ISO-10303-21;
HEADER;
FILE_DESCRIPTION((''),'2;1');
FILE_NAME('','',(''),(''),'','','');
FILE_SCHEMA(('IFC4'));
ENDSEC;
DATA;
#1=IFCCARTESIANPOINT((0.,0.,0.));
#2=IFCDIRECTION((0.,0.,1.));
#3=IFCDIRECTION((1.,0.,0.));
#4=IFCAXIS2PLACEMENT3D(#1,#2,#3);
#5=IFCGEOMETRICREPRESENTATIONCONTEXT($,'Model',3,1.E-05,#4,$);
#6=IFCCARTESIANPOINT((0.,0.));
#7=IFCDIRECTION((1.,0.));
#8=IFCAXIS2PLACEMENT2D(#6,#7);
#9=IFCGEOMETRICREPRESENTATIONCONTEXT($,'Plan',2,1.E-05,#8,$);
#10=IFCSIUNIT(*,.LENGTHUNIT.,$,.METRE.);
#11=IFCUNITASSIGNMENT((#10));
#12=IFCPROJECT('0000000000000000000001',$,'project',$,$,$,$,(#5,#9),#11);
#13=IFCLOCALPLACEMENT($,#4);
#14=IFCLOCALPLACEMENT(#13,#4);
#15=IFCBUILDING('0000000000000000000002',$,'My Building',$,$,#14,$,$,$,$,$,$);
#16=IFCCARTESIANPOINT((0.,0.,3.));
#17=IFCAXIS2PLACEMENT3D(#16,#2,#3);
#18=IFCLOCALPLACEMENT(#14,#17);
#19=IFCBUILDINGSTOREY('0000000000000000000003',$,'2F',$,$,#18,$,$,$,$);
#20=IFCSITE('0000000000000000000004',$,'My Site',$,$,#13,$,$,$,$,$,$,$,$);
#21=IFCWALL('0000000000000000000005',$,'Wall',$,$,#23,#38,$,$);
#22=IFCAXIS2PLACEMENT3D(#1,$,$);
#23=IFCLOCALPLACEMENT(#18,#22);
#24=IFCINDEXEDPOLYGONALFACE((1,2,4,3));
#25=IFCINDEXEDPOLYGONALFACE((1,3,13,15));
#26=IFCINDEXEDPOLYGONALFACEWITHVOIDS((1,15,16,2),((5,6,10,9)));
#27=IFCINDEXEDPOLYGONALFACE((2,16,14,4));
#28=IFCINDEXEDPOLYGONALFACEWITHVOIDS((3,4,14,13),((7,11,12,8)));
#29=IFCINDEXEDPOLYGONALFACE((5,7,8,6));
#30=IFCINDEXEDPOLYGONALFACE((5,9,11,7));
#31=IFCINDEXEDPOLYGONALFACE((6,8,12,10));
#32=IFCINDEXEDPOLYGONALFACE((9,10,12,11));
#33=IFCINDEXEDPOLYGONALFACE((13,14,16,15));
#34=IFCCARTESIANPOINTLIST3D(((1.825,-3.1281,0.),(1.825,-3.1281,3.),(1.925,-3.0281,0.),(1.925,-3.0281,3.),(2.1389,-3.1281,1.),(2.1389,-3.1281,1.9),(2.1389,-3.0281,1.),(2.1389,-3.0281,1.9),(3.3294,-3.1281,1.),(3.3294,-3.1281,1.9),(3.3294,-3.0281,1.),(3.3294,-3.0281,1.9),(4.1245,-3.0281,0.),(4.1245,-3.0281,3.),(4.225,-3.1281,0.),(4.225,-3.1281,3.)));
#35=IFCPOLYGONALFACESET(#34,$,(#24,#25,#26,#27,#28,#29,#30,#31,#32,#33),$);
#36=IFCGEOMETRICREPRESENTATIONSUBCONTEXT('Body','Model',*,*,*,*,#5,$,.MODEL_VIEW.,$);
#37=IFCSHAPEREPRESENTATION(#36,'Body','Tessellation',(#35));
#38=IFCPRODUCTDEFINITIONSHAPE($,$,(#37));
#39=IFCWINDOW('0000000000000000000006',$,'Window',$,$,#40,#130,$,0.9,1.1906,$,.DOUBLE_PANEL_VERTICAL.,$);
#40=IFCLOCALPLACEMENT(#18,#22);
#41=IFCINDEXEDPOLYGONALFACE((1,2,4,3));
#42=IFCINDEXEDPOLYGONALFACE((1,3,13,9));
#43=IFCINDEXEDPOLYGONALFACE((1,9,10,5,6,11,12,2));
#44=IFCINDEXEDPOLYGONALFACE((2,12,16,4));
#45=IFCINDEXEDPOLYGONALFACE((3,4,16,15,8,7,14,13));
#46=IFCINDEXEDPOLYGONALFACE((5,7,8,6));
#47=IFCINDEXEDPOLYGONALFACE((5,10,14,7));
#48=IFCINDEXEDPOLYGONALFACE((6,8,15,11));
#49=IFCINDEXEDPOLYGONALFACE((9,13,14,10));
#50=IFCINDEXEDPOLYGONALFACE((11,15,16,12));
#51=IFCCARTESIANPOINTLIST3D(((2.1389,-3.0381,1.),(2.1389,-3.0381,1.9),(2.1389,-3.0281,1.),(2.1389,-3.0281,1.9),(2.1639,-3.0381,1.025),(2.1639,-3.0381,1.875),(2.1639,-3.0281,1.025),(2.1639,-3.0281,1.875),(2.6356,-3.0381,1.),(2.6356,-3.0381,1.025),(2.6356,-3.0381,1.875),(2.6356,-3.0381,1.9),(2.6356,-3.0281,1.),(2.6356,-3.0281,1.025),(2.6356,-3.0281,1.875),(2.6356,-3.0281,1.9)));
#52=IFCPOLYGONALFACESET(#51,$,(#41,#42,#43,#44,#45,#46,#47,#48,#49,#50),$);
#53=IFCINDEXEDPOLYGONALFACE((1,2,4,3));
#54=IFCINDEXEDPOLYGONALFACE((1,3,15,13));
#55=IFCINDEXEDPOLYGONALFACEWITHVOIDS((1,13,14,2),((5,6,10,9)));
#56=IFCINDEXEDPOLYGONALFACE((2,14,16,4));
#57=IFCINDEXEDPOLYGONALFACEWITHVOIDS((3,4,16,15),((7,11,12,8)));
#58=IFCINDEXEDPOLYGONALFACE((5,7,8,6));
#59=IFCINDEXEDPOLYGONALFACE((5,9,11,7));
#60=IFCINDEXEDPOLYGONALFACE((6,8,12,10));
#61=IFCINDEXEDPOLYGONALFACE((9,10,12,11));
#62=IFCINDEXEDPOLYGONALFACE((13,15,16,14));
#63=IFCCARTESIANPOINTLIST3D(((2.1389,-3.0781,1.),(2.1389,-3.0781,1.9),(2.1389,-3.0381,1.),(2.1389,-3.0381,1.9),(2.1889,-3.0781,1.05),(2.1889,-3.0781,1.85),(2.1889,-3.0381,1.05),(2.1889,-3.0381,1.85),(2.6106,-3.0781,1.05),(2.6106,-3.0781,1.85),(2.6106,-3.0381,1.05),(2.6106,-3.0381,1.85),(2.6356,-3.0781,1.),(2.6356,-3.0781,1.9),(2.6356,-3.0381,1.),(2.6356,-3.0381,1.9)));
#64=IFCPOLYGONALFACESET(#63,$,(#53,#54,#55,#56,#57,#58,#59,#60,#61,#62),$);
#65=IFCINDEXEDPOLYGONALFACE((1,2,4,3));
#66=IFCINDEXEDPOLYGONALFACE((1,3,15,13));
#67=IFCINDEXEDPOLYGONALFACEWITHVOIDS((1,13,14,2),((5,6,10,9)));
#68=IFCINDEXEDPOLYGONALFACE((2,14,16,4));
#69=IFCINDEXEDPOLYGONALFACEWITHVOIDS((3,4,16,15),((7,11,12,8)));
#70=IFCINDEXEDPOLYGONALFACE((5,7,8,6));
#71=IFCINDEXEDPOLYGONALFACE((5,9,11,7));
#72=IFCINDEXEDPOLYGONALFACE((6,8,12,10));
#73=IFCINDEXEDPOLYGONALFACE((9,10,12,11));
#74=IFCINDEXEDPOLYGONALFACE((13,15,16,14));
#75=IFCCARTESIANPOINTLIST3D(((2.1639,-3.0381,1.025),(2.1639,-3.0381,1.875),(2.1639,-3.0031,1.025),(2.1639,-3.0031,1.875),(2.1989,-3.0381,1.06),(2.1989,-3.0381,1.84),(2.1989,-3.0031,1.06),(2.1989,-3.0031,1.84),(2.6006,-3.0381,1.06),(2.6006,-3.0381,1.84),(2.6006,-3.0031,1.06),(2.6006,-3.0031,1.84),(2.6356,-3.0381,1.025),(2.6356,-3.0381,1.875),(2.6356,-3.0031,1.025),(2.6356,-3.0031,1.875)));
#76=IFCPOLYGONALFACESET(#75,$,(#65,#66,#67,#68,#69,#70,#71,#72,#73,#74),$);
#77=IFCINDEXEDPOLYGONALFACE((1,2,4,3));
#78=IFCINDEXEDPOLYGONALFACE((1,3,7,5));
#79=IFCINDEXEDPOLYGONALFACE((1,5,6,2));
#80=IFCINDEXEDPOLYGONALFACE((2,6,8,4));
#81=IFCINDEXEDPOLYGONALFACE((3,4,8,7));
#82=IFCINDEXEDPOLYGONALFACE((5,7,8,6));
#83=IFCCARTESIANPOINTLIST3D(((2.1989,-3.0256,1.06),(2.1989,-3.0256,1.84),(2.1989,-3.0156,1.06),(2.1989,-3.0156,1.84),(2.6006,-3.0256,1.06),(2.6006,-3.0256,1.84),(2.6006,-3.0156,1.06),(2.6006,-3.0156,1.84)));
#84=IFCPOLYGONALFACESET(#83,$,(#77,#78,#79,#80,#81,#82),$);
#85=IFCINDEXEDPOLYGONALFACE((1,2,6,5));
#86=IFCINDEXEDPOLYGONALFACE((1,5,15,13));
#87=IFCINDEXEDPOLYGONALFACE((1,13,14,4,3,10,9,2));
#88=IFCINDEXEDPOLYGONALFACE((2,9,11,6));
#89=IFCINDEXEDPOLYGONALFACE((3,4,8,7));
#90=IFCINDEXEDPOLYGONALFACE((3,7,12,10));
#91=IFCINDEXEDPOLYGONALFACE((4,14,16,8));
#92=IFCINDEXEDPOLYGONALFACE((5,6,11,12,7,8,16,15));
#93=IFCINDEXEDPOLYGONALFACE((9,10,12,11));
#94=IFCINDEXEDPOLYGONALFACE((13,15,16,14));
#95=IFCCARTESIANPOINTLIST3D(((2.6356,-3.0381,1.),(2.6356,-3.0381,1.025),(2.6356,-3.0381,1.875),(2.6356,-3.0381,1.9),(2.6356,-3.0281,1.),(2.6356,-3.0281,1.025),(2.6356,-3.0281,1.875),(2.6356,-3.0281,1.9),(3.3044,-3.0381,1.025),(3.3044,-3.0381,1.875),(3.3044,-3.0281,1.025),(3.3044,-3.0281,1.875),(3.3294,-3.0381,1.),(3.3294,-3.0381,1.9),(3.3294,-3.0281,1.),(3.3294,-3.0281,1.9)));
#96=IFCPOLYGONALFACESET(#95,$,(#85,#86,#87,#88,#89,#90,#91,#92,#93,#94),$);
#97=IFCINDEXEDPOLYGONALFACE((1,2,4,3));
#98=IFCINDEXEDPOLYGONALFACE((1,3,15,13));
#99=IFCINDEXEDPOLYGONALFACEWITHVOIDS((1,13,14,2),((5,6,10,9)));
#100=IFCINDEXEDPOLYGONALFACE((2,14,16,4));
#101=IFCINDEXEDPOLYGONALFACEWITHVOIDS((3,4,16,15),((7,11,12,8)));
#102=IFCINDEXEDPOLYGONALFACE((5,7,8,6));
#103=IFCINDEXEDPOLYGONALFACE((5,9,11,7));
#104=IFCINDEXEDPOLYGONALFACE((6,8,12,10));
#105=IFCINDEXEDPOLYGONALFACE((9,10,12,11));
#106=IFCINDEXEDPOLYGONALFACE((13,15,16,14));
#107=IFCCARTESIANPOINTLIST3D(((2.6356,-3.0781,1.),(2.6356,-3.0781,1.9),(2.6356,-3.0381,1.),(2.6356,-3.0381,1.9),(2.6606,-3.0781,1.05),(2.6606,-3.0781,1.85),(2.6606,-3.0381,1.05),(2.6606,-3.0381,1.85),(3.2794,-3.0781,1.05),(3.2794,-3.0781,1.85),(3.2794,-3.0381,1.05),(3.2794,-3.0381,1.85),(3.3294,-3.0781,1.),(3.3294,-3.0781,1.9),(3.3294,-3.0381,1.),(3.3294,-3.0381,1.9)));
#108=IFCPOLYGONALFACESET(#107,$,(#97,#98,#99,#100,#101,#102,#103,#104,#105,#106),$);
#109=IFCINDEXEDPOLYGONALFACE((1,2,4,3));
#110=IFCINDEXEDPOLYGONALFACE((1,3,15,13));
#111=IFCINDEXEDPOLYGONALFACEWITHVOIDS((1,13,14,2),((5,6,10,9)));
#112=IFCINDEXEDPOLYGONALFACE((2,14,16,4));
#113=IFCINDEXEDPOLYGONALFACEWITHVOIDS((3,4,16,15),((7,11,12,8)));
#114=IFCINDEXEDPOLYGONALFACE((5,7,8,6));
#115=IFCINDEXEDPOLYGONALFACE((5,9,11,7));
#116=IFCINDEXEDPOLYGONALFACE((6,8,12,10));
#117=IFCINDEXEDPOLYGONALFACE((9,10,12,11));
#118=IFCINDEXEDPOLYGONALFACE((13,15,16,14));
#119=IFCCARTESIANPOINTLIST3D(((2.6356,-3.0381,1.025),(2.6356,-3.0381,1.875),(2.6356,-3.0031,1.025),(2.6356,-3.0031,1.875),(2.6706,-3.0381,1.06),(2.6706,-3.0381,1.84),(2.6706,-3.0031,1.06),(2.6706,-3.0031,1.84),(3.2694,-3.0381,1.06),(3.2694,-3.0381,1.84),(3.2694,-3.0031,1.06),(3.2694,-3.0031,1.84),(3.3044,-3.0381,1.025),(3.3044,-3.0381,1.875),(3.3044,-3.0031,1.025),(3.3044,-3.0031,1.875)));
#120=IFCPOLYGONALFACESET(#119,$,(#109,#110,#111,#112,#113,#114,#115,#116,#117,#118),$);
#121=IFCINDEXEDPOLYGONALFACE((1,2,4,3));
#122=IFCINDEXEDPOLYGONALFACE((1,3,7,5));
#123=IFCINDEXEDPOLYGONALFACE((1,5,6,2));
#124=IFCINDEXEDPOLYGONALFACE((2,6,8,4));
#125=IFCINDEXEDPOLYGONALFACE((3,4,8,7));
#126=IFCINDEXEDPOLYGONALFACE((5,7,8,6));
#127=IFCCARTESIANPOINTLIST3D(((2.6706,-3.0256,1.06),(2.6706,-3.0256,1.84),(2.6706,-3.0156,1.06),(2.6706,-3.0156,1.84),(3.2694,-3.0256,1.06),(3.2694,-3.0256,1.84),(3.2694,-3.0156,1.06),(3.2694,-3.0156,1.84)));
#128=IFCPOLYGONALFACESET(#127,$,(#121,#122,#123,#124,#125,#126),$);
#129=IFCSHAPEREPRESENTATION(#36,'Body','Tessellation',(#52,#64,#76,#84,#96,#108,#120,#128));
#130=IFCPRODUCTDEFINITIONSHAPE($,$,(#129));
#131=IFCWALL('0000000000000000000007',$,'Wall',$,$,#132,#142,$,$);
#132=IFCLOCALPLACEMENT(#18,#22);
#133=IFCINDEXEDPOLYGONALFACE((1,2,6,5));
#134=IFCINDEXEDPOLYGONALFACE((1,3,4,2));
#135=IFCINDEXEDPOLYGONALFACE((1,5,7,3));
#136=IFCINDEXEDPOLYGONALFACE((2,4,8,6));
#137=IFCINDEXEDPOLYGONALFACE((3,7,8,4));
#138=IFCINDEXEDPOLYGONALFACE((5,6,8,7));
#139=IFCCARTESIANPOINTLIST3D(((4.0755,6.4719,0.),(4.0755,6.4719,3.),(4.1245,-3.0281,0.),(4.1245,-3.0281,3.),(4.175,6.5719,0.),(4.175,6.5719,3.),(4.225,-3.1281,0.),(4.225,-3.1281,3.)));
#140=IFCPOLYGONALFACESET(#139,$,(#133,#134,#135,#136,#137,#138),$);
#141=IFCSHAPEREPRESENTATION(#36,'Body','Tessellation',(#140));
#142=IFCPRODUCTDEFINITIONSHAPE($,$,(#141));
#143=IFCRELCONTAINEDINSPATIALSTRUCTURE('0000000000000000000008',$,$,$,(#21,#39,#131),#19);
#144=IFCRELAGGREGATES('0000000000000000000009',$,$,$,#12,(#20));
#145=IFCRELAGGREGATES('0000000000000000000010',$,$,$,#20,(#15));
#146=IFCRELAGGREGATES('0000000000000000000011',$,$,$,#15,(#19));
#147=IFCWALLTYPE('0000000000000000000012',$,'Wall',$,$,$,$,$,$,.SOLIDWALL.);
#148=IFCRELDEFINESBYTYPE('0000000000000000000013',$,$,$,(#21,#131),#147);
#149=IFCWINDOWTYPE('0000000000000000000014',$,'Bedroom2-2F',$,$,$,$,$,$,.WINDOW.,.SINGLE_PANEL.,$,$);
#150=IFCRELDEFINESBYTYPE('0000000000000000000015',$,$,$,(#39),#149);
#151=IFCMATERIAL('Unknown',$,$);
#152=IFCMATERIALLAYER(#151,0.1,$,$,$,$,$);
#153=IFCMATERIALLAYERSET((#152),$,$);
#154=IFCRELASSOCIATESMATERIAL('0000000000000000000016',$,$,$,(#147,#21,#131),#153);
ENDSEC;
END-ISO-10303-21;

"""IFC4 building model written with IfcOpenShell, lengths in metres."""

from ifc_helpers import new_model, entity, si_unit, frame, origin_with_axes, origin_2d_with_axis, place, context, subcontext, project, spatial, line, indexed_curve, outline, extrude, shape, source, transform, mapped, material, layer, layer_set, layer_usage, type_object, type_shapes, element, fill, save


model = new_model("IFC4")

# Units and contexts
model_context = context("Model", 3, precision=1e-05, world=origin_with_axes())
plan_context = context("Plan", 2, precision=1e-05, world=origin_2d_with_axis())
body_context_1 = subcontext(model_context, "Body", "Model", "MODEL_VIEW")
body_context_2 = subcontext(plan_context, "Body", "Plan", "PLAN_VIEW")
ifc_project = project(units=[si_unit("LENGTHUNIT", "METRE")], contexts=[model_context, plan_context])

# Site, building, storey
site_placement = place(None, origin_with_axes())
site = spatial("IfcSite", under=ifc_project, at=site_placement, Name="My Site")
building_placement = place(site_placement, origin_with_axes())
building = spatial("IfcBuilding", under=site, at=building_placement, Name="My Building")
storey_placement = place(building_placement, frame((0.0, 0.0, 3.0), z_axis=(0.0, 0.0, 1.0), x_axis=(1.0, 0.0, 0.0)))
storey = spatial("IfcBuildingStorey", under=building, at=storey_placement, Name="2F")

# Shared definitions
ifc_material = material(Name="Unknown")

# Shared definitions
ifc_layer_1 = layer(ifc_material, 0.1)
ifc_layer_set_1 = layer_set([ifc_layer_1])
wall_type = type_object("IfcWallType", Name="Wall", PredefinedType="SOLIDWALL", material=ifc_layer_set_1)

# Wall, opening, window
ifc_layer_usage_1 = layer_usage(ifc_layer_set_1, "AXIS2", "POSITIVE", 0.0)
wall_1_placement = place(storey_placement, frame((1.825, -3.1281, 0.0), z_axis=(0.0, 0.0, 1.0), x_axis=(1.0, 0.0, 0.0)))
wall_1 = element("IfcWall", 1, at=wall_1_placement, inside=storey, type_object=wall_type, material=ifc_layer_usage_1, Name="Wall", context=body_context_1, shape_type="SweptSolid", body=[
    extrude(outline(indexed_curve([(0.0, 0.0), (0.1, 0.1), (2.2995, 0.1), (2.4, 0.0)], segments=[line(1, 2, 3, 4, 1)])), origin_with_axes(), (0.0, 0.0, 1.0), 3.0),
])
shared_shape_1 = source(origin_with_axes(), body_context_1, "Body", "SweptSolid", [
    extrude(outline(indexed_curve([(0.0, 0.0), (1.1906, 0.0), (1.1906, 0.9), (0.0, 0.9)], segments=[line(1, 2, 3, 4, 1)])), frame((0.0, -0.6, 0.0), z_axis=(0.0, -1.0, 0.0), x_axis=(1.0, 0.0, 0.0)), (0.0, 0.0, -1.0), 1.2),
])
opening_1_placement = place(wall_1_placement, frame((0.3139, 0.0, 1.0), z_axis=(0.0, 0.0, 1.0), x_axis=(1.0, 0.0, 0.0)))
opening_1 = element("IfcOpeningElement", 2, at=opening_1_placement, cuts=wall_1, PredefinedType="OPENING", context=body_context_1, shape_type="MappedRepresentation", body=[
    mapped(shared_shape_1, transform((0.0, 0.0, 0.0), x_axis=(1.0, 0.0, 0.0), y_axis=(0.0, 1.0, 0.0), z_axis=(0.0, 0.0, 1.0), scale=1.0)),
])
window_type = type_object("IfcWindowType", Name="Bedroom2-2F", PartitioningType="SINGLE_PANEL", PredefinedType="WINDOW")
shared_shape_2 = source(origin_with_axes(), body_context_1, "Body", "SweptSolid", [
    extrude(outline(indexed_curve([(0.4967, 0.0), (0.0, 0.0), (0.0, 0.9), (0.4967, 0.9), (0.4967, 0.875), (0.025, 0.875), (0.025, 0.025), (0.4967, 0.025)], segments=[line(1, 2, 3, 4, 5, 6, 7, 8, 1)])), frame((0.0, 0.09, 0.0), z_axis=(0.0, -1.0, 0.0), x_axis=(1.0, 0.0, 0.0)), (0.0, 0.0, -1.0), 0.01),
    extrude(outline(indexed_curve([(0.0, 0.0), (0.4967, 0.0), (0.4967, 0.9), (0.0, 0.9)], segments=[line(1, 2, 3, 4, 1)]), holes=[indexed_curve([(0.05, 0.05), (0.4717, 0.05), (0.4717, 0.85), (0.05, 0.85)], segments=[line(1, 2, 3, 4, 1)])]), frame((0.0, 0.05, 0.0), z_axis=(0.0, -1.0, 0.0), x_axis=(1.0, 0.0, 0.0)), (0.0, 0.0, -1.0), 0.04),
    extrude(outline(indexed_curve([(0.0, 0.0), (0.4717, 0.0), (0.4717, 0.85), (0.0, 0.85)], segments=[line(1, 2, 3, 4, 1)]), holes=[indexed_curve([(0.035, 0.035), (0.4367, 0.035), (0.4367, 0.815), (0.035, 0.815)], segments=[line(1, 2, 3, 4, 1)])]), frame((0.025, 0.09, 0.025), z_axis=(0.0, -1.0, 0.0), x_axis=(1.0, 0.0, 0.0)), (0.0, 0.0, -1.0), 0.035),
    extrude(outline(indexed_curve([(0.035, 0.035), (0.4367, 0.035), (0.4367, 0.815), (0.035, 0.815)], segments=[line(1, 2, 3, 4, 1)])), frame((0.025, 0.1025, 0.025), z_axis=(0.0, -1.0, 0.0), x_axis=(1.0, 0.0, 0.0)), (0.0, 0.0, -1.0), 0.01),
    extrude(outline(indexed_curve([(0.0, 0.9), (0.6938, 0.9), (0.6938, 0.0), (0.0, 0.0), (0.0, 0.025), (0.6688, 0.025), (0.6688, 0.875), (0.0, 0.875)], segments=[line(1, 2, 3, 4, 5, 6, 7, 8, 1)])), frame((0.4967, 0.09, 0.0), z_axis=(0.0, -1.0, 0.0), x_axis=(1.0, 0.0, 0.0)), (0.0, 0.0, -1.0), 0.01),
    extrude(outline(indexed_curve([(0.0, 0.0), (0.6938, 0.0), (0.6938, 0.9), (0.0, 0.9)], segments=[line(1, 2, 3, 4, 1)]), holes=[indexed_curve([(0.025, 0.05), (0.6438, 0.05), (0.6438, 0.85), (0.025, 0.85)], segments=[line(1, 2, 3, 4, 1)])]), frame((0.4967, 0.05, 0.0), z_axis=(0.0, -1.0, 0.0), x_axis=(1.0, 0.0, 0.0)), (0.0, 0.0, -1.0), 0.04),
    extrude(outline(indexed_curve([(0.0, 0.0), (0.6688, 0.0), (0.6688, 0.85), (0.0, 0.85)], segments=[line(1, 2, 3, 4, 1)]), holes=[indexed_curve([(0.035, 0.035), (0.6338, 0.035), (0.6338, 0.815), (0.035, 0.815)], segments=[line(1, 2, 3, 4, 1)])]), frame((0.4967, 0.09, 0.025), z_axis=(0.0, -1.0, 0.0), x_axis=(1.0, 0.0, 0.0)), (0.0, 0.0, -1.0), 0.035),
    extrude(outline(indexed_curve([(0.035, 0.035), (0.6338, 0.035), (0.6338, 0.815), (0.035, 0.815)], segments=[line(1, 2, 3, 4, 1)])), frame((0.4967, 0.1025, 0.025), z_axis=(0.0, -1.0, 0.0), x_axis=(1.0, 0.0, 0.0)), (0.0, 0.0, -1.0), 0.01),
])
shared_shape_3 = source(origin_with_axes(), body_context_2, "Body", "Curve2D", [
    entity("IfcIndexedPolyCurve", entity("IfcCartesianPointList2D", [[0.05, 0.05], [0.4717, 0.05]])),
    entity("IfcIndexedPolyCurve", entity("IfcCartesianPointList2D", [[0.0, 0.1], [0.025, 0.1], [0.025, 0.09], [0.05, 0.09], [0.05, 0.05], [0.0, 0.05]]), [entity("IfcLineIndex", [1, 2, 3, 4, 5, 6, 1])]),
    entity("IfcIndexedPolyCurve", entity("IfcCartesianPointList2D", [[0.4967, 0.1], [0.4967, 0.1], [0.4967, 0.09], [0.4717, 0.09], [0.4717, 0.05], [0.4967, 0.05]])),
    entity("IfcIndexedPolyCurve", entity("IfcCartesianPointList2D", [[0.025, 0.09], [0.06, 0.09], [0.06, 0.125], [0.025, 0.125]]), [entity("IfcLineIndex", [1, 2, 3, 4, 1])]),
    entity("IfcIndexedPolyCurve", entity("IfcCartesianPointList2D", [[0.4967, 0.09], [0.4617, 0.09], [0.4617, 0.125], [0.4967, 0.125]]), [entity("IfcLineIndex", [1, 2, 3, 4, 1])]),
    entity("IfcIndexedPolyCurve", entity("IfcCartesianPointList2D", [[0.06, 0.09], [0.4617, 0.09]])),
    entity("IfcIndexedPolyCurve", entity("IfcCartesianPointList2D", [[0.06, 0.125], [0.4617, 0.125]])),
    entity("IfcIndexedPolyCurve", entity("IfcCartesianPointList2D", [[0.06, 0.1075], [0.4617, 0.1075]])),
    entity("IfcIndexedPolyCurve", entity("IfcCartesianPointList2D", [[0.5217, 0.05], [1.1406, 0.05]])),
    entity("IfcIndexedPolyCurve", entity("IfcCartesianPointList2D", [[0.4967, 0.1], [0.4967, 0.1], [0.4967, 0.09], [0.5217, 0.09], [0.5217, 0.05], [0.4967, 0.05]])),
    entity("IfcIndexedPolyCurve", entity("IfcCartesianPointList2D", [[1.1906, 0.1], [1.1656, 0.1], [1.1656, 0.09], [1.1406, 0.09], [1.1406, 0.05], [1.1906, 0.05]]), [entity("IfcLineIndex", [1, 2, 3, 4, 5, 6, 1])]),
    entity("IfcIndexedPolyCurve", entity("IfcCartesianPointList2D", [[0.4967, 0.09], [0.5317, 0.09], [0.5317, 0.125], [0.4967, 0.125]]), [entity("IfcLineIndex", [1, 2, 3, 4, 1])]),
    entity("IfcIndexedPolyCurve", entity("IfcCartesianPointList2D", [[1.1656, 0.09], [1.1306, 0.09], [1.1306, 0.125], [1.1656, 0.125]]), [entity("IfcLineIndex", [1, 2, 3, 4, 1])]),
    entity("IfcIndexedPolyCurve", entity("IfcCartesianPointList2D", [[0.5317, 0.09], [1.1306, 0.09]])),
    entity("IfcIndexedPolyCurve", entity("IfcCartesianPointList2D", [[0.5317, 0.125], [1.1306, 0.125]])),
    entity("IfcIndexedPolyCurve", entity("IfcCartesianPointList2D", [[0.5317, 0.1075], [1.1306, 0.1075]])),
])
type_shapes(window_type, [shared_shape_2, shared_shape_3])
window_placement = place(opening_1_placement, origin_with_axes())
window = element("IfcWindow", 3, at=window_placement, inside=storey, type_object=window_type, Name="Window", OverallHeight=0.9, OverallWidth=1.1906, PartitioningType="DOUBLE_PANEL_VERTICAL", shapes=[
    shape(body_context_1, "Body", "MappedRepresentation", [mapped(shared_shape_2, transform((0.0, 0.0, 0.0), x_axis=(1.0, 0.0, 0.0), y_axis=(0.0, 1.0, 0.0), z_axis=(0.0, 0.0, 1.0), scale=1.0))]),
    shape(body_context_2, "Body", "MappedRepresentation", [mapped(shared_shape_3, transform((0.0, 0.0, 0.0), x_axis=(1.0, 0.0, 0.0), y_axis=(0.0, 1.0, 0.0), z_axis=(0.0, 0.0, 1.0), scale=1.0))]),
])
fill(opening_1, window)

# Wall
ifc_layer_usage_2 = layer_usage(ifc_layer_set_1, "AXIS2", "POSITIVE", 0.0)
wall_2_placement = place(storey_placement, frame((4.225, -3.1281, 0.0), z_axis=(0.0, 0.0, 1.0), x_axis=(-0.005155, 0.999987, 0.0)))
element("IfcWall", 4, at=wall_2_placement, inside=storey, type_object=wall_type, material=ifc_layer_usage_2, Name="Wall", context=body_context_1, shape_type="SweptSolid", body=[
    extrude(outline(indexed_curve([(0.0, 0.0), (0.1005, 0.1), (9.6006, 0.1), (9.7001, 0.0)], segments=[line(1, 2, 3, 4, 1)])), origin_with_axes(), (0.0, 0.0, 1.0), 3.0),
])

save(model, "model.ifc")
